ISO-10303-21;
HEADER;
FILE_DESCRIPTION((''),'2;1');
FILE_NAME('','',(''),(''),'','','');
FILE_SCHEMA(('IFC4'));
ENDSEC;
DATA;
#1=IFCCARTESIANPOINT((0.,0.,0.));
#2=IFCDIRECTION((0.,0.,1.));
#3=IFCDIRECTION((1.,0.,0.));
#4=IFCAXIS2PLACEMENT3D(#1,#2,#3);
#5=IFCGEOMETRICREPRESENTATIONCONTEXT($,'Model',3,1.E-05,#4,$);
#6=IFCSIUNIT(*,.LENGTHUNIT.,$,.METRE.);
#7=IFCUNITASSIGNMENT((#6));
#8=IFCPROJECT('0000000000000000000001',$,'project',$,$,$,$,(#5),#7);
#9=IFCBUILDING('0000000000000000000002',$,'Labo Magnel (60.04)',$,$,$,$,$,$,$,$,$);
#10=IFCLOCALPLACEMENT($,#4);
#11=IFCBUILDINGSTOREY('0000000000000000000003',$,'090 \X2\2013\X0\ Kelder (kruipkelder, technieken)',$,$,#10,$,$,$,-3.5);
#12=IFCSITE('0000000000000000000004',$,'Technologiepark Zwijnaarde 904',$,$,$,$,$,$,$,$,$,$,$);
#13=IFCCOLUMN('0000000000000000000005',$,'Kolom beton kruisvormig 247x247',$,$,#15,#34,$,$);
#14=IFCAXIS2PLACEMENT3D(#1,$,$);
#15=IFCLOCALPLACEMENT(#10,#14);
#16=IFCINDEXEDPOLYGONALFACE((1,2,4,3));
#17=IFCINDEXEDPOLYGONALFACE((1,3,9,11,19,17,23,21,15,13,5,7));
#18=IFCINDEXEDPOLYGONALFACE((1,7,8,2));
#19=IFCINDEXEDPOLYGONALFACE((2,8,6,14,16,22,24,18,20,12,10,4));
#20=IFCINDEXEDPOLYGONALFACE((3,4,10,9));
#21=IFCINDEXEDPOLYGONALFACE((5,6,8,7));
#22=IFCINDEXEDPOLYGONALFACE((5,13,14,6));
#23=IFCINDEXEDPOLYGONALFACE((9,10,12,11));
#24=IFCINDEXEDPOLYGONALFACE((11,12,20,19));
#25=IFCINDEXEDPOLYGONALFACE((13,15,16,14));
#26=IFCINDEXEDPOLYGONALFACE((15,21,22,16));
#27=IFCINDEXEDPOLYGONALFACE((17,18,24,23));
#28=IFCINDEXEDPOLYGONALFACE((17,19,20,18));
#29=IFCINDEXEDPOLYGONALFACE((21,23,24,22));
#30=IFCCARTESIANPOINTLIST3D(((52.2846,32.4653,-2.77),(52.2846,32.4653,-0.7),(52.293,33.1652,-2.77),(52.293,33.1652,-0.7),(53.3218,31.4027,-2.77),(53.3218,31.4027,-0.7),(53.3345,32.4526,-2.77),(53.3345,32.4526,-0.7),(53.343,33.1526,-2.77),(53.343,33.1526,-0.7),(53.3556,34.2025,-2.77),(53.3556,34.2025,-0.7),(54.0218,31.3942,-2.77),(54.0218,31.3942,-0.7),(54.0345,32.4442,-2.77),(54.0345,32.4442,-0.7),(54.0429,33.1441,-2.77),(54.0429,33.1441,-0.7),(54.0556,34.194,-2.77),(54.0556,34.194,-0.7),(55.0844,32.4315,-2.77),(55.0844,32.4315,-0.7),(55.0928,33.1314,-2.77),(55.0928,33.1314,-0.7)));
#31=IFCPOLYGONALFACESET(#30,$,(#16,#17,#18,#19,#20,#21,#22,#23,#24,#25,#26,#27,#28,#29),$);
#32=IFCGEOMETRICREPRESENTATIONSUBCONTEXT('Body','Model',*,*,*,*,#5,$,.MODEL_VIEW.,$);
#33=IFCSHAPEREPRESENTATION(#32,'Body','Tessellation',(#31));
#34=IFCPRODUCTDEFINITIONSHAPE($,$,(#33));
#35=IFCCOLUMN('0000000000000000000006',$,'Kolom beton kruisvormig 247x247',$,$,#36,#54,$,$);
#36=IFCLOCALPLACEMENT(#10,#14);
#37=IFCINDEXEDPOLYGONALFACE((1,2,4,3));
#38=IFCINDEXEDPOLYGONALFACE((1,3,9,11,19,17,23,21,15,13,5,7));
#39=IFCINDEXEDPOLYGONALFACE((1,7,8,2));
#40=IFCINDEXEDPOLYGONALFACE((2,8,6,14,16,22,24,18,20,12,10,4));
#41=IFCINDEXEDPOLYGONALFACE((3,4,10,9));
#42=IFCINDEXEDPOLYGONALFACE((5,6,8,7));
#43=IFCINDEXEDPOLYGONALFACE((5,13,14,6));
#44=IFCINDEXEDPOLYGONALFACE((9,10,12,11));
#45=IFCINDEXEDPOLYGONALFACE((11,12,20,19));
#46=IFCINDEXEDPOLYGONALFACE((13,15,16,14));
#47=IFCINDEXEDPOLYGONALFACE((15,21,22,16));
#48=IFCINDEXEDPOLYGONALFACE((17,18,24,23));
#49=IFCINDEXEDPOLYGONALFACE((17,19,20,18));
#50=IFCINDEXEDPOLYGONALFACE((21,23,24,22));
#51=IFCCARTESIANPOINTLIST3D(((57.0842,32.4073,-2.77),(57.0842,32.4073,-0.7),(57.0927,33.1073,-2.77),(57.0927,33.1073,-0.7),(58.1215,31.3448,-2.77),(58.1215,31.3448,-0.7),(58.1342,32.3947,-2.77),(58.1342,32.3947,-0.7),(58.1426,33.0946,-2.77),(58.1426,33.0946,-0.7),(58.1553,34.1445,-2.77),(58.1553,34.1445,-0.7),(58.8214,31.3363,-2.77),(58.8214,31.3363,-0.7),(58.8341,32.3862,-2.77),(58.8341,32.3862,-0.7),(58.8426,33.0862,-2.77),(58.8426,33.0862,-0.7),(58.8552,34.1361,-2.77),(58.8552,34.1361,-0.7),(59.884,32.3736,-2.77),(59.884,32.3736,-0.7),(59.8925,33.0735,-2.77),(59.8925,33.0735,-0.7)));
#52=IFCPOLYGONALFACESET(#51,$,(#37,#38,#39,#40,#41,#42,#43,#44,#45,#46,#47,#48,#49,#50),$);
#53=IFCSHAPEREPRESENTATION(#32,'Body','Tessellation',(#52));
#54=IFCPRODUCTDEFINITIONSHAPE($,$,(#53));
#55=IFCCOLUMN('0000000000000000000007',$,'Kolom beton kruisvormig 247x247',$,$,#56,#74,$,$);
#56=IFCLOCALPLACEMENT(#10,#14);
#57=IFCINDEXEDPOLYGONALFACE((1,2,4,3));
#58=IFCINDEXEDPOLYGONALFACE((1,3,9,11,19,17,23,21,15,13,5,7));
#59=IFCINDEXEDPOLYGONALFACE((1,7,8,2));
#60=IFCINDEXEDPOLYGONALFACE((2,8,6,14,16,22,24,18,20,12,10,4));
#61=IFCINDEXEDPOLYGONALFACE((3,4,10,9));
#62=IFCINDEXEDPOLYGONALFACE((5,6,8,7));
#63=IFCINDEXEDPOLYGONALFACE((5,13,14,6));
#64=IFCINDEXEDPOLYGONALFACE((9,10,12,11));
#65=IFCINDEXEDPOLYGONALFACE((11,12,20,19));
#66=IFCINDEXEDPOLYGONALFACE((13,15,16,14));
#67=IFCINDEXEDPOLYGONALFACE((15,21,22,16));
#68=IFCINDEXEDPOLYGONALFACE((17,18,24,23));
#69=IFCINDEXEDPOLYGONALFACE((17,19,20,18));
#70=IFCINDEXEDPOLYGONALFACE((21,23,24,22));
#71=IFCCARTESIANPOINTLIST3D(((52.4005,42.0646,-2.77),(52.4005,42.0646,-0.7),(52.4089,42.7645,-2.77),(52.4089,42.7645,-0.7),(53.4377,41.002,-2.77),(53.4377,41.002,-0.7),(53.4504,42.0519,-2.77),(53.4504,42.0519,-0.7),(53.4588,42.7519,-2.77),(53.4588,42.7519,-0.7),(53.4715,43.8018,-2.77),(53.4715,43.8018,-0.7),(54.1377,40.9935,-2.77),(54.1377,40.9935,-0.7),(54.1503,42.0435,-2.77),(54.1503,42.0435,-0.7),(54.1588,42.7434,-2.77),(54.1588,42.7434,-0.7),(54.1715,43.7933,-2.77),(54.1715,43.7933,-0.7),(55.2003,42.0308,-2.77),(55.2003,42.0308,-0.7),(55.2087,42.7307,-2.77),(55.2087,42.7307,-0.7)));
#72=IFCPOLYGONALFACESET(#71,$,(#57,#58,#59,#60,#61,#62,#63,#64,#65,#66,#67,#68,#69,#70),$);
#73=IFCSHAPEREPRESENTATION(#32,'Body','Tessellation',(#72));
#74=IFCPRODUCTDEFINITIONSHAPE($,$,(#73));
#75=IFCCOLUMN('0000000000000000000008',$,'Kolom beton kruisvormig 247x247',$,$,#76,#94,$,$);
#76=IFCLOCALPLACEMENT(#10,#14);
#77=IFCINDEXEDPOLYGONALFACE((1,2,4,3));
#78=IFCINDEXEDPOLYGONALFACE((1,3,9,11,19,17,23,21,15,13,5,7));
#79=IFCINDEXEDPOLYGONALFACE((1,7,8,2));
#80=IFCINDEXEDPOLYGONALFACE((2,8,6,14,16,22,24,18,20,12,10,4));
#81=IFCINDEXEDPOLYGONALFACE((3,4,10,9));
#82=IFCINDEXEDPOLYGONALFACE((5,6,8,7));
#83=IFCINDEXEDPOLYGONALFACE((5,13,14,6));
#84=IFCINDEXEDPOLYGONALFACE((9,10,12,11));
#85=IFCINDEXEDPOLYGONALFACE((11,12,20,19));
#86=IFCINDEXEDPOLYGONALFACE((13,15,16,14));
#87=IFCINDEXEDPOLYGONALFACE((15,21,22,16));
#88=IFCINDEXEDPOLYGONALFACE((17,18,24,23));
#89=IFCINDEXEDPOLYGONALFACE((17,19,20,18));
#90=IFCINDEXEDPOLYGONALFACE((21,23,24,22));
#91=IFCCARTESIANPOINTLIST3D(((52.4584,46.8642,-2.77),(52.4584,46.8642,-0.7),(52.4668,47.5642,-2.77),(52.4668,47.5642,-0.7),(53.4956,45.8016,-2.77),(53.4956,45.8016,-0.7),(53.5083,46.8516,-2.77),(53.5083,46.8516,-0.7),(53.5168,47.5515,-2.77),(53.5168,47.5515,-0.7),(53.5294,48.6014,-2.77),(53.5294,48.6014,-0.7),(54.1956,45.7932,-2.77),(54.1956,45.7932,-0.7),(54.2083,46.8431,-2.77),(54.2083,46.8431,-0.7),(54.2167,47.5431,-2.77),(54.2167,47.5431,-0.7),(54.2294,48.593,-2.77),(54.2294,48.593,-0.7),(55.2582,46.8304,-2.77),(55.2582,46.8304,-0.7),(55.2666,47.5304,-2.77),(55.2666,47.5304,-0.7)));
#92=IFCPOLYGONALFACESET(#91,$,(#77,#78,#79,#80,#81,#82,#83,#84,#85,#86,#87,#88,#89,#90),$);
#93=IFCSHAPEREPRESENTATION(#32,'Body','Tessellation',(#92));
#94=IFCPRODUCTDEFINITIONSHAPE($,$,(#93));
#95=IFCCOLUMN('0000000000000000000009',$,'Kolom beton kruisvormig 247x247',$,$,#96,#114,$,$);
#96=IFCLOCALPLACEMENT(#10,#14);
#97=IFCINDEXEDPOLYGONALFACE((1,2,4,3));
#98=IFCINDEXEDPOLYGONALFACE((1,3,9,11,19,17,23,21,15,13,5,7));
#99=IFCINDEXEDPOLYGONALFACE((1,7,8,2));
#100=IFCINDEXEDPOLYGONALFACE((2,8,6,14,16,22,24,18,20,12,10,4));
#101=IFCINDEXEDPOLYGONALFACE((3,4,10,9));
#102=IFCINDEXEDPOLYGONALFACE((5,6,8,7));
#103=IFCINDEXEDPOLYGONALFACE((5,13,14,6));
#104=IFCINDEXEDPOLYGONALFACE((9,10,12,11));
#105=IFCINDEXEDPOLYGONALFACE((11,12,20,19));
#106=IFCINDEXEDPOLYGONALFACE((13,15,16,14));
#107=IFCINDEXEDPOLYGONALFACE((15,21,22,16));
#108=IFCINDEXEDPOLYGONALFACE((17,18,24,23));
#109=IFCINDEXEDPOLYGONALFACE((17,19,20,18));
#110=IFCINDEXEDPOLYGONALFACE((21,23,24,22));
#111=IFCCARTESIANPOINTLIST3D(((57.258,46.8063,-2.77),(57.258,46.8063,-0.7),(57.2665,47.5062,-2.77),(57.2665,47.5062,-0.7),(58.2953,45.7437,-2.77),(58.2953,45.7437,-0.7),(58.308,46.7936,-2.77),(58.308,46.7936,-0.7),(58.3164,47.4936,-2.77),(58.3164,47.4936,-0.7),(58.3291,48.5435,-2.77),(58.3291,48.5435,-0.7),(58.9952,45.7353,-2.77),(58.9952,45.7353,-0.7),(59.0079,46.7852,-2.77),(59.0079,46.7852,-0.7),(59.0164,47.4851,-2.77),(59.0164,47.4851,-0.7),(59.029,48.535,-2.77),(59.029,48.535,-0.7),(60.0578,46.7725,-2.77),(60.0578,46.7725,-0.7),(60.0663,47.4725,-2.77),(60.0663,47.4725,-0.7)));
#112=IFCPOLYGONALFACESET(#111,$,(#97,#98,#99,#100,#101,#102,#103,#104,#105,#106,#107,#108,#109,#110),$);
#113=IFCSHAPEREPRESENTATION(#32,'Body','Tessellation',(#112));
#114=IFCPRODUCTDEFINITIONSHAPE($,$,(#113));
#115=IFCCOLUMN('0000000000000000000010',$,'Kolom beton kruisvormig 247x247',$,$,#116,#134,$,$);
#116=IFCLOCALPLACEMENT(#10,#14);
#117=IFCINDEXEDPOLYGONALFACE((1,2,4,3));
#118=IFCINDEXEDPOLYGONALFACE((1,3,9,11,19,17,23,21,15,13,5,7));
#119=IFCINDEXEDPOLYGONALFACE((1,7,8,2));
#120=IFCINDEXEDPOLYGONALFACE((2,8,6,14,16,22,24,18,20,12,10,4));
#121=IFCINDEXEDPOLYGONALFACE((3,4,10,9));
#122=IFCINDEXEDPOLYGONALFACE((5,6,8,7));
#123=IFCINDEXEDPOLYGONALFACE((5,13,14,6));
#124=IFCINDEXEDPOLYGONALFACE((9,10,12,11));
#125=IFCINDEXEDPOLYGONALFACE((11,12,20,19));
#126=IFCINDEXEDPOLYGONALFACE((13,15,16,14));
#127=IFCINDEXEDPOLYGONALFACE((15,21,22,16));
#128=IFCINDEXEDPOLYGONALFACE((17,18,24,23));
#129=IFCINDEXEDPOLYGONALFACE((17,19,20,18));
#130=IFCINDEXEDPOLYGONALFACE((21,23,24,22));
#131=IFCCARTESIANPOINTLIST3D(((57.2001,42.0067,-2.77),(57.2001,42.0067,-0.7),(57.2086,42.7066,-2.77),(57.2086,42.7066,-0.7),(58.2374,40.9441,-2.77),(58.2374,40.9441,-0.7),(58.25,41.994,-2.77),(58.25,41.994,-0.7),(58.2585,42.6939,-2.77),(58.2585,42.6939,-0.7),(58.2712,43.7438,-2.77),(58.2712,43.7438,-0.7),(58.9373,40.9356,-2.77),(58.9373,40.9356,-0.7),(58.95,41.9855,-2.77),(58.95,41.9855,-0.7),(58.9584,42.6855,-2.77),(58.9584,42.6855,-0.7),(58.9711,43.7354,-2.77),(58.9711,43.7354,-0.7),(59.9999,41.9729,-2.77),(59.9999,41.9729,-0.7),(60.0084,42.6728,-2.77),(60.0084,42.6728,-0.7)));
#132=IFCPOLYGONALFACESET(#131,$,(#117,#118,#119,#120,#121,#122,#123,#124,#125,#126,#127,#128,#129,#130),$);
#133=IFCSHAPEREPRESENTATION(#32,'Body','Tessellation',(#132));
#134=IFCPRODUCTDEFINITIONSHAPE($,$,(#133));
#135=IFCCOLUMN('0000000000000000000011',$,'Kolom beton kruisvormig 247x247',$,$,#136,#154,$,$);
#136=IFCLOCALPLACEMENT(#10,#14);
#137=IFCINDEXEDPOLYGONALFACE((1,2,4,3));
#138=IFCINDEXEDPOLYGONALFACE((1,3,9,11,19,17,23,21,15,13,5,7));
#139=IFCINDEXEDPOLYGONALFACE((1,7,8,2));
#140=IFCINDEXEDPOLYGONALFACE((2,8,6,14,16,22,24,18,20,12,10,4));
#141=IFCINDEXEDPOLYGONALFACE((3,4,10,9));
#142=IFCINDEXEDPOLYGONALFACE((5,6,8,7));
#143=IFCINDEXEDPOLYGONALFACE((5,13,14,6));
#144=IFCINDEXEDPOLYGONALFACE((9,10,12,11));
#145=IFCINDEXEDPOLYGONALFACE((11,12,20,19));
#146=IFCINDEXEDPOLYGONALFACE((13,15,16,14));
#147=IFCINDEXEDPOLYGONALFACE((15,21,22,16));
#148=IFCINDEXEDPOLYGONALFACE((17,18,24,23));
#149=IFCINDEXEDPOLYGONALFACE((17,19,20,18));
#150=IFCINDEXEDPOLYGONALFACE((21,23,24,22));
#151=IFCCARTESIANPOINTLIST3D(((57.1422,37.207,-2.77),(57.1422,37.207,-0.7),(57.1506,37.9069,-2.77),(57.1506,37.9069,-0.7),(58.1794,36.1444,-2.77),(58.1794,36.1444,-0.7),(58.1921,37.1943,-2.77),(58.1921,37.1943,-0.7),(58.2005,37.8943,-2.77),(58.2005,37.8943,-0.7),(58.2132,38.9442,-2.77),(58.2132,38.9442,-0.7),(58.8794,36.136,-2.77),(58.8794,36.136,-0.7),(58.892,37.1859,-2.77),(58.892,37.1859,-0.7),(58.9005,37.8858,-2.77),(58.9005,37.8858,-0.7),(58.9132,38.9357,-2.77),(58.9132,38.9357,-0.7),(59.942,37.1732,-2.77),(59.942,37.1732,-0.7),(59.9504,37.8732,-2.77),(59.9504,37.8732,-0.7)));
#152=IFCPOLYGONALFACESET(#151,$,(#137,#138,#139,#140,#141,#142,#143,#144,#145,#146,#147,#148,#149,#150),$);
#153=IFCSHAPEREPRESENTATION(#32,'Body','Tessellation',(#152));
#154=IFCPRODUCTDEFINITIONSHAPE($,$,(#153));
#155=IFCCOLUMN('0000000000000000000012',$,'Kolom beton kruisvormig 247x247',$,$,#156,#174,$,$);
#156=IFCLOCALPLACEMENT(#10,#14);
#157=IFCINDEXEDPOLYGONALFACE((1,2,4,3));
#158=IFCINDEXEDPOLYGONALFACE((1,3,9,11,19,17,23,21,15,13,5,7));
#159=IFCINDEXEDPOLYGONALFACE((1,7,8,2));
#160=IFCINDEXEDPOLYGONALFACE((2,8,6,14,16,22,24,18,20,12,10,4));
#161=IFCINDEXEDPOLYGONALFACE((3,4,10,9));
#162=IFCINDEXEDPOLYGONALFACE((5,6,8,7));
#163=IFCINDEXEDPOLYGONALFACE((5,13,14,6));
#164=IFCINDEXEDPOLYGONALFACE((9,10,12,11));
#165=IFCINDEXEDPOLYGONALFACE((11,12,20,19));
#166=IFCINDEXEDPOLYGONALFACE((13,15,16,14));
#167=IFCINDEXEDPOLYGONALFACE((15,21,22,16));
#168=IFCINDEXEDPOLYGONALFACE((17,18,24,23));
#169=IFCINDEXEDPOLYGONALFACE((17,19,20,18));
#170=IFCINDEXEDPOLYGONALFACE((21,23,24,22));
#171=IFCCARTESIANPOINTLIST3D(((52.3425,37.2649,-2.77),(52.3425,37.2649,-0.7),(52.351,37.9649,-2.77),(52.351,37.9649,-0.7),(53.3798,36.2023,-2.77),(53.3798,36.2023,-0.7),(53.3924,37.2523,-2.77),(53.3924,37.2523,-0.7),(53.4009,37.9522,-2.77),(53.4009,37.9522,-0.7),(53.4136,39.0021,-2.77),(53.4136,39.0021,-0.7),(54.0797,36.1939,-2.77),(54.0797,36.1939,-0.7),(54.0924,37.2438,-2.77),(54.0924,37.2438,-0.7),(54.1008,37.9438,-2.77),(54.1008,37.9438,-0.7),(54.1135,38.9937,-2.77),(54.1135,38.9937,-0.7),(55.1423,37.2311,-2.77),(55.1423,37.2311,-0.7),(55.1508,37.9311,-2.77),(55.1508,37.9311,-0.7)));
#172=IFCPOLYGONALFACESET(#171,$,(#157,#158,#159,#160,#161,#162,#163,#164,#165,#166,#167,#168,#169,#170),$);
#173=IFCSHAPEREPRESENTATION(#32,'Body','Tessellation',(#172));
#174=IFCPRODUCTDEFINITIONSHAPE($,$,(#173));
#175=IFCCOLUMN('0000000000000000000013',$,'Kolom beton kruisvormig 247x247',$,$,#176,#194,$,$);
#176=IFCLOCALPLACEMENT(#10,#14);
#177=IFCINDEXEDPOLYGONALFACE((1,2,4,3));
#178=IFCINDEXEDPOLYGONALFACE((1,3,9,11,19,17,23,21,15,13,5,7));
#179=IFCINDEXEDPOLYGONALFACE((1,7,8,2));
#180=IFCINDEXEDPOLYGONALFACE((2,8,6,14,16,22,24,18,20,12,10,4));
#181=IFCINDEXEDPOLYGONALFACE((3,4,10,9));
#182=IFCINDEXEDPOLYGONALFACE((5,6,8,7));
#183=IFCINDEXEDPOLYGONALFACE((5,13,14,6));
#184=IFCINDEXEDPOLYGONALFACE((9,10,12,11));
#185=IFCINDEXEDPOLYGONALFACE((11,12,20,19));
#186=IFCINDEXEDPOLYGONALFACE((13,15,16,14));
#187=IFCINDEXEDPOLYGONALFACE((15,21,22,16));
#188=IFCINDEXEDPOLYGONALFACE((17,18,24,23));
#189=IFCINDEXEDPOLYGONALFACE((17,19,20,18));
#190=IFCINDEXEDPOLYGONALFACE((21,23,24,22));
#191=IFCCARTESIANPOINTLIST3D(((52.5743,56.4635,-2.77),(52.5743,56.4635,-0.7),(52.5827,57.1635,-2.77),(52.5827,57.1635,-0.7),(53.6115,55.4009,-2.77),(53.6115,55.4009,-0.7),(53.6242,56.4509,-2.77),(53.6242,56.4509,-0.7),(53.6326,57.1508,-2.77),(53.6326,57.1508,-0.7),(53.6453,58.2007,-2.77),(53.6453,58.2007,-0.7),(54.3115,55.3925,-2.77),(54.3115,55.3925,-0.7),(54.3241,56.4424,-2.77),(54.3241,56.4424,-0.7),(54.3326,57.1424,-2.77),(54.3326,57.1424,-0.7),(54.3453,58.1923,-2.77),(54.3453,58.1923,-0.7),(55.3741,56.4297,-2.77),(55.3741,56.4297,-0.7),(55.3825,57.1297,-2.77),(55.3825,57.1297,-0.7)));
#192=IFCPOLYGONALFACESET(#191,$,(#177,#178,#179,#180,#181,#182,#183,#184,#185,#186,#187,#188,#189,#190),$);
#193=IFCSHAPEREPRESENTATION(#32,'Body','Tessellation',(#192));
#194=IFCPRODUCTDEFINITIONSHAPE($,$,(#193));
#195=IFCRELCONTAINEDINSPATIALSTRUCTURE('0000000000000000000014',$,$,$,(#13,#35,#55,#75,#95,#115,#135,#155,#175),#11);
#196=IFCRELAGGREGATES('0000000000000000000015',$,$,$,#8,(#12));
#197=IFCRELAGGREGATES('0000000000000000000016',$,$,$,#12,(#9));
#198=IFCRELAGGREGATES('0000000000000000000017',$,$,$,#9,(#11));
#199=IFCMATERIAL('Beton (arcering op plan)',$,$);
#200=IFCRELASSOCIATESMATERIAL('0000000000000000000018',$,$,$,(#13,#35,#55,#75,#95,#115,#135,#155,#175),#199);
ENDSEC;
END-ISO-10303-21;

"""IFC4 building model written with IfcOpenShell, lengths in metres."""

from ifc_helpers import new_model, si_unit, frame, origin, origin_with_axes, place, context, subcontext, project, spatial, polyline, outline, extrude, material, element, save


model = new_model("IFC4")

# Units and contexts
model_context = context("Model", 3, precision=1e-05, world=origin_with_axes())
body_context = subcontext(model_context, "Body", "Model", "MODEL_VIEW")
ifc_project = project(units=[si_unit("LENGTHUNIT", "METRE")], contexts=[model_context])

# Site, building, storey
site = spatial("IfcSite", under=ifc_project, Name="Technologiepark Zwijnaarde 904")
building = spatial("IfcBuilding", under=site, Name="Labo Magnel (60.04)")
storey_placement = place(None, origin_with_axes())
storey = spatial("IfcBuildingStorey", under=building, at=storey_placement, Name="090 – Kelder (kruipkelder, technieken)", Elevation=-3.5)

# Shared definitions
ifc_material_1 = material(Name="Beton (arcering op plan)")

# Columns
column_1_placement = place(storey_placement, frame((0.0, 0.0, -2.77), z_axis=(0.0, 0.0, 1.0), x_axis=(1.0, 0.0, 0.0)))
element("IfcColumn", 1, at=column_1_placement, inside=storey, material=ifc_material_1, Name="Kolom beton kruisvormig 247x247", context=body_context, shape_type="SweptSolid", body=[
    extrude(outline(polyline([(55.0928, 33.1314), (54.0429, 33.1441), (54.0556, 34.194), (53.3556, 34.2025), (53.343, 33.1526), (52.293, 33.1652), (52.2846, 32.4653), (53.3345, 32.4526), (53.3218, 31.4027), (54.0218, 31.3942), (54.0345, 32.4442), (55.0844, 32.4315), (55.0928, 33.1314)])), origin(), (0.0, 0.0, 1.0), 2.07),
])
column_2_placement = place(storey_placement, frame((0.0, 0.0, -2.77), z_axis=(0.0, 0.0, 1.0), x_axis=(1.0, 0.0, 0.0)))
element("IfcColumn", 2, at=column_2_placement, inside=storey, material=ifc_material_1, Name="Kolom beton kruisvormig 247x247", context=body_context, shape_type="SweptSolid", body=[
    extrude(outline(polyline([(59.8925, 33.0735), (58.8426, 33.0862), (58.8552, 34.1361), (58.1553, 34.1445), (58.1426, 33.0946), (57.0927, 33.1073), (57.0842, 32.4073), (58.1342, 32.3947), (58.1215, 31.3448), (58.8214, 31.3363), (58.8341, 32.3862), (59.884, 32.3736), (59.8925, 33.0735)])), origin(), (0.0, 0.0, 1.0), 2.07),
])
column_3_placement = place(storey_placement, frame((0.0, 0.0, -2.77), z_axis=(0.0, 0.0, 1.0), x_axis=(1.0, 0.0, 0.0)))
element("IfcColumn", 3, at=column_3_placement, inside=storey, material=ifc_material_1, Name="Kolom beton kruisvormig 247x247", context=body_context, shape_type="SweptSolid", body=[
    extrude(outline(polyline([(55.2087, 42.7307), (54.1588, 42.7434), (54.1715, 43.7933), (53.4715, 43.8018), (53.4588, 42.7519), (52.4089, 42.7645), (52.4005, 42.0646), (53.4504, 42.0519), (53.4377, 41.002), (54.1377, 40.9935), (54.1503, 42.0435), (55.2003, 42.0308), (55.2087, 42.7307)])), origin(), (0.0, 0.0, 1.0), 2.07),
])
column_4_placement = place(storey_placement, frame((0.0, 0.0, -2.77), z_axis=(0.0, 0.0, 1.0), x_axis=(1.0, 0.0, 0.0)))
element("IfcColumn", 4, at=column_4_placement, inside=storey, material=ifc_material_1, Name="Kolom beton kruisvormig 247x247", context=body_context, shape_type="SweptSolid", body=[
    extrude(outline(polyline([(55.2666, 47.5304), (54.2167, 47.5431), (54.2294, 48.593), (53.5294, 48.6014), (53.5168, 47.5515), (52.4668, 47.5642), (52.4584, 46.8642), (53.5083, 46.8516), (53.4956, 45.8016), (54.1956, 45.7932), (54.2083, 46.8431), (55.2582, 46.8304), (55.2666, 47.5304)])), origin(), (0.0, 0.0, 1.0), 2.07),
])
column_5_placement = place(storey_placement, frame((0.0, 0.0, -2.77), z_axis=(0.0, 0.0, 1.0), x_axis=(1.0, 0.0, 0.0)))
element("IfcColumn", 5, at=column_5_placement, inside=storey, material=ifc_material_1, Name="Kolom beton kruisvormig 247x247", context=body_context, shape_type="SweptSolid", body=[
    extrude(outline(polyline([(60.0663, 47.4725), (59.0164, 47.4851), (59.029, 48.535), (58.3291, 48.5435), (58.3164, 47.4936), (57.2665, 47.5062), (57.258, 46.8063), (58.308, 46.7936), (58.2953, 45.7437), (58.9952, 45.7353), (59.0079, 46.7852), (60.0578, 46.7725), (60.0663, 47.4725)])), origin(), (0.0, 0.0, 1.0), 2.07),
])
column_6_placement = place(storey_placement, frame((0.0, 0.0, -2.77), z_axis=(0.0, 0.0, 1.0), x_axis=(1.0, 0.0, 0.0)))
element("IfcColumn", 6, at=column_6_placement, inside=storey, material=ifc_material_1, Name="Kolom beton kruisvormig 247x247", context=body_context, shape_type="SweptSolid", body=[
    extrude(outline(polyline([(60.0084, 42.6728), (58.9584, 42.6855), (58.9711, 43.7354), (58.2712, 43.7438), (58.2585, 42.6939), (57.2086, 42.7066), (57.2001, 42.0067), (58.25, 41.994), (58.2374, 40.9441), (58.9373, 40.9356), (58.95, 41.9855), (59.9999, 41.9729), (60.0084, 42.6728)])), origin(), (0.0, 0.0, 1.0), 2.07),
])
column_7_placement = place(storey_placement, frame((0.0, 0.0, -2.77), z_axis=(0.0, 0.0, 1.0), x_axis=(1.0, 0.0, 0.0)))
element("IfcColumn", 7, at=column_7_placement, inside=storey, material=ifc_material_1, Name="Kolom beton kruisvormig 247x247", context=body_context, shape_type="SweptSolid", body=[
    extrude(outline(polyline([(59.9504, 37.8732), (58.9005, 37.8858), (58.9132, 38.9357), (58.2132, 38.9442), (58.2005, 37.8943), (57.1506, 37.9069), (57.1422, 37.207), (58.1921, 37.1943), (58.1794, 36.1444), (58.8794, 36.136), (58.892, 37.1859), (59.942, 37.1732), (59.9504, 37.8732)])), origin(), (0.0, 0.0, 1.0), 2.07),
])
column_8_placement = place(storey_placement, frame((0.0, 0.0, -2.77), z_axis=(0.0, 0.0, 1.0), x_axis=(1.0, 0.0, 0.0)))
element("IfcColumn", 8, at=column_8_placement, inside=storey, material=ifc_material_1, Name="Kolom beton kruisvormig 247x247", context=body_context, shape_type="SweptSolid", body=[
    extrude(outline(polyline([(55.1508, 37.9311), (54.1008, 37.9438), (54.1135, 38.9937), (53.4136, 39.0021), (53.4009, 37.9522), (52.351, 37.9649), (52.3425, 37.2649), (53.3924, 37.2523), (53.3798, 36.2023), (54.0797, 36.1939), (54.0924, 37.2438), (55.1423, 37.2311), (55.1508, 37.9311)])), origin(), (0.0, 0.0, 1.0), 2.07),
])
column_9_placement = place(storey_placement, frame((0.0, 0.0, -2.77), z_axis=(0.0, 0.0, 1.0), x_axis=(1.0, 0.0, 0.0)))
element("IfcColumn", 9, at=column_9_placement, inside=storey, material=ifc_material_1, Name="Kolom beton kruisvormig 247x247", context=body_context, shape_type="SweptSolid", body=[
    extrude(outline(polyline([(55.3825, 57.1297), (54.3326, 57.1424), (54.3453, 58.1923), (53.6453, 58.2007), (53.6326, 57.1508), (52.5827, 57.1635), (52.5743, 56.4635), (53.6242, 56.4509), (53.6115, 55.4009), (54.3115, 55.3925), (54.3241, 56.4424), (55.3741, 56.4297), (55.3825, 57.1297)])), origin(), (0.0, 0.0, 1.0), 2.07),
])

save(model, "model.ifc")
